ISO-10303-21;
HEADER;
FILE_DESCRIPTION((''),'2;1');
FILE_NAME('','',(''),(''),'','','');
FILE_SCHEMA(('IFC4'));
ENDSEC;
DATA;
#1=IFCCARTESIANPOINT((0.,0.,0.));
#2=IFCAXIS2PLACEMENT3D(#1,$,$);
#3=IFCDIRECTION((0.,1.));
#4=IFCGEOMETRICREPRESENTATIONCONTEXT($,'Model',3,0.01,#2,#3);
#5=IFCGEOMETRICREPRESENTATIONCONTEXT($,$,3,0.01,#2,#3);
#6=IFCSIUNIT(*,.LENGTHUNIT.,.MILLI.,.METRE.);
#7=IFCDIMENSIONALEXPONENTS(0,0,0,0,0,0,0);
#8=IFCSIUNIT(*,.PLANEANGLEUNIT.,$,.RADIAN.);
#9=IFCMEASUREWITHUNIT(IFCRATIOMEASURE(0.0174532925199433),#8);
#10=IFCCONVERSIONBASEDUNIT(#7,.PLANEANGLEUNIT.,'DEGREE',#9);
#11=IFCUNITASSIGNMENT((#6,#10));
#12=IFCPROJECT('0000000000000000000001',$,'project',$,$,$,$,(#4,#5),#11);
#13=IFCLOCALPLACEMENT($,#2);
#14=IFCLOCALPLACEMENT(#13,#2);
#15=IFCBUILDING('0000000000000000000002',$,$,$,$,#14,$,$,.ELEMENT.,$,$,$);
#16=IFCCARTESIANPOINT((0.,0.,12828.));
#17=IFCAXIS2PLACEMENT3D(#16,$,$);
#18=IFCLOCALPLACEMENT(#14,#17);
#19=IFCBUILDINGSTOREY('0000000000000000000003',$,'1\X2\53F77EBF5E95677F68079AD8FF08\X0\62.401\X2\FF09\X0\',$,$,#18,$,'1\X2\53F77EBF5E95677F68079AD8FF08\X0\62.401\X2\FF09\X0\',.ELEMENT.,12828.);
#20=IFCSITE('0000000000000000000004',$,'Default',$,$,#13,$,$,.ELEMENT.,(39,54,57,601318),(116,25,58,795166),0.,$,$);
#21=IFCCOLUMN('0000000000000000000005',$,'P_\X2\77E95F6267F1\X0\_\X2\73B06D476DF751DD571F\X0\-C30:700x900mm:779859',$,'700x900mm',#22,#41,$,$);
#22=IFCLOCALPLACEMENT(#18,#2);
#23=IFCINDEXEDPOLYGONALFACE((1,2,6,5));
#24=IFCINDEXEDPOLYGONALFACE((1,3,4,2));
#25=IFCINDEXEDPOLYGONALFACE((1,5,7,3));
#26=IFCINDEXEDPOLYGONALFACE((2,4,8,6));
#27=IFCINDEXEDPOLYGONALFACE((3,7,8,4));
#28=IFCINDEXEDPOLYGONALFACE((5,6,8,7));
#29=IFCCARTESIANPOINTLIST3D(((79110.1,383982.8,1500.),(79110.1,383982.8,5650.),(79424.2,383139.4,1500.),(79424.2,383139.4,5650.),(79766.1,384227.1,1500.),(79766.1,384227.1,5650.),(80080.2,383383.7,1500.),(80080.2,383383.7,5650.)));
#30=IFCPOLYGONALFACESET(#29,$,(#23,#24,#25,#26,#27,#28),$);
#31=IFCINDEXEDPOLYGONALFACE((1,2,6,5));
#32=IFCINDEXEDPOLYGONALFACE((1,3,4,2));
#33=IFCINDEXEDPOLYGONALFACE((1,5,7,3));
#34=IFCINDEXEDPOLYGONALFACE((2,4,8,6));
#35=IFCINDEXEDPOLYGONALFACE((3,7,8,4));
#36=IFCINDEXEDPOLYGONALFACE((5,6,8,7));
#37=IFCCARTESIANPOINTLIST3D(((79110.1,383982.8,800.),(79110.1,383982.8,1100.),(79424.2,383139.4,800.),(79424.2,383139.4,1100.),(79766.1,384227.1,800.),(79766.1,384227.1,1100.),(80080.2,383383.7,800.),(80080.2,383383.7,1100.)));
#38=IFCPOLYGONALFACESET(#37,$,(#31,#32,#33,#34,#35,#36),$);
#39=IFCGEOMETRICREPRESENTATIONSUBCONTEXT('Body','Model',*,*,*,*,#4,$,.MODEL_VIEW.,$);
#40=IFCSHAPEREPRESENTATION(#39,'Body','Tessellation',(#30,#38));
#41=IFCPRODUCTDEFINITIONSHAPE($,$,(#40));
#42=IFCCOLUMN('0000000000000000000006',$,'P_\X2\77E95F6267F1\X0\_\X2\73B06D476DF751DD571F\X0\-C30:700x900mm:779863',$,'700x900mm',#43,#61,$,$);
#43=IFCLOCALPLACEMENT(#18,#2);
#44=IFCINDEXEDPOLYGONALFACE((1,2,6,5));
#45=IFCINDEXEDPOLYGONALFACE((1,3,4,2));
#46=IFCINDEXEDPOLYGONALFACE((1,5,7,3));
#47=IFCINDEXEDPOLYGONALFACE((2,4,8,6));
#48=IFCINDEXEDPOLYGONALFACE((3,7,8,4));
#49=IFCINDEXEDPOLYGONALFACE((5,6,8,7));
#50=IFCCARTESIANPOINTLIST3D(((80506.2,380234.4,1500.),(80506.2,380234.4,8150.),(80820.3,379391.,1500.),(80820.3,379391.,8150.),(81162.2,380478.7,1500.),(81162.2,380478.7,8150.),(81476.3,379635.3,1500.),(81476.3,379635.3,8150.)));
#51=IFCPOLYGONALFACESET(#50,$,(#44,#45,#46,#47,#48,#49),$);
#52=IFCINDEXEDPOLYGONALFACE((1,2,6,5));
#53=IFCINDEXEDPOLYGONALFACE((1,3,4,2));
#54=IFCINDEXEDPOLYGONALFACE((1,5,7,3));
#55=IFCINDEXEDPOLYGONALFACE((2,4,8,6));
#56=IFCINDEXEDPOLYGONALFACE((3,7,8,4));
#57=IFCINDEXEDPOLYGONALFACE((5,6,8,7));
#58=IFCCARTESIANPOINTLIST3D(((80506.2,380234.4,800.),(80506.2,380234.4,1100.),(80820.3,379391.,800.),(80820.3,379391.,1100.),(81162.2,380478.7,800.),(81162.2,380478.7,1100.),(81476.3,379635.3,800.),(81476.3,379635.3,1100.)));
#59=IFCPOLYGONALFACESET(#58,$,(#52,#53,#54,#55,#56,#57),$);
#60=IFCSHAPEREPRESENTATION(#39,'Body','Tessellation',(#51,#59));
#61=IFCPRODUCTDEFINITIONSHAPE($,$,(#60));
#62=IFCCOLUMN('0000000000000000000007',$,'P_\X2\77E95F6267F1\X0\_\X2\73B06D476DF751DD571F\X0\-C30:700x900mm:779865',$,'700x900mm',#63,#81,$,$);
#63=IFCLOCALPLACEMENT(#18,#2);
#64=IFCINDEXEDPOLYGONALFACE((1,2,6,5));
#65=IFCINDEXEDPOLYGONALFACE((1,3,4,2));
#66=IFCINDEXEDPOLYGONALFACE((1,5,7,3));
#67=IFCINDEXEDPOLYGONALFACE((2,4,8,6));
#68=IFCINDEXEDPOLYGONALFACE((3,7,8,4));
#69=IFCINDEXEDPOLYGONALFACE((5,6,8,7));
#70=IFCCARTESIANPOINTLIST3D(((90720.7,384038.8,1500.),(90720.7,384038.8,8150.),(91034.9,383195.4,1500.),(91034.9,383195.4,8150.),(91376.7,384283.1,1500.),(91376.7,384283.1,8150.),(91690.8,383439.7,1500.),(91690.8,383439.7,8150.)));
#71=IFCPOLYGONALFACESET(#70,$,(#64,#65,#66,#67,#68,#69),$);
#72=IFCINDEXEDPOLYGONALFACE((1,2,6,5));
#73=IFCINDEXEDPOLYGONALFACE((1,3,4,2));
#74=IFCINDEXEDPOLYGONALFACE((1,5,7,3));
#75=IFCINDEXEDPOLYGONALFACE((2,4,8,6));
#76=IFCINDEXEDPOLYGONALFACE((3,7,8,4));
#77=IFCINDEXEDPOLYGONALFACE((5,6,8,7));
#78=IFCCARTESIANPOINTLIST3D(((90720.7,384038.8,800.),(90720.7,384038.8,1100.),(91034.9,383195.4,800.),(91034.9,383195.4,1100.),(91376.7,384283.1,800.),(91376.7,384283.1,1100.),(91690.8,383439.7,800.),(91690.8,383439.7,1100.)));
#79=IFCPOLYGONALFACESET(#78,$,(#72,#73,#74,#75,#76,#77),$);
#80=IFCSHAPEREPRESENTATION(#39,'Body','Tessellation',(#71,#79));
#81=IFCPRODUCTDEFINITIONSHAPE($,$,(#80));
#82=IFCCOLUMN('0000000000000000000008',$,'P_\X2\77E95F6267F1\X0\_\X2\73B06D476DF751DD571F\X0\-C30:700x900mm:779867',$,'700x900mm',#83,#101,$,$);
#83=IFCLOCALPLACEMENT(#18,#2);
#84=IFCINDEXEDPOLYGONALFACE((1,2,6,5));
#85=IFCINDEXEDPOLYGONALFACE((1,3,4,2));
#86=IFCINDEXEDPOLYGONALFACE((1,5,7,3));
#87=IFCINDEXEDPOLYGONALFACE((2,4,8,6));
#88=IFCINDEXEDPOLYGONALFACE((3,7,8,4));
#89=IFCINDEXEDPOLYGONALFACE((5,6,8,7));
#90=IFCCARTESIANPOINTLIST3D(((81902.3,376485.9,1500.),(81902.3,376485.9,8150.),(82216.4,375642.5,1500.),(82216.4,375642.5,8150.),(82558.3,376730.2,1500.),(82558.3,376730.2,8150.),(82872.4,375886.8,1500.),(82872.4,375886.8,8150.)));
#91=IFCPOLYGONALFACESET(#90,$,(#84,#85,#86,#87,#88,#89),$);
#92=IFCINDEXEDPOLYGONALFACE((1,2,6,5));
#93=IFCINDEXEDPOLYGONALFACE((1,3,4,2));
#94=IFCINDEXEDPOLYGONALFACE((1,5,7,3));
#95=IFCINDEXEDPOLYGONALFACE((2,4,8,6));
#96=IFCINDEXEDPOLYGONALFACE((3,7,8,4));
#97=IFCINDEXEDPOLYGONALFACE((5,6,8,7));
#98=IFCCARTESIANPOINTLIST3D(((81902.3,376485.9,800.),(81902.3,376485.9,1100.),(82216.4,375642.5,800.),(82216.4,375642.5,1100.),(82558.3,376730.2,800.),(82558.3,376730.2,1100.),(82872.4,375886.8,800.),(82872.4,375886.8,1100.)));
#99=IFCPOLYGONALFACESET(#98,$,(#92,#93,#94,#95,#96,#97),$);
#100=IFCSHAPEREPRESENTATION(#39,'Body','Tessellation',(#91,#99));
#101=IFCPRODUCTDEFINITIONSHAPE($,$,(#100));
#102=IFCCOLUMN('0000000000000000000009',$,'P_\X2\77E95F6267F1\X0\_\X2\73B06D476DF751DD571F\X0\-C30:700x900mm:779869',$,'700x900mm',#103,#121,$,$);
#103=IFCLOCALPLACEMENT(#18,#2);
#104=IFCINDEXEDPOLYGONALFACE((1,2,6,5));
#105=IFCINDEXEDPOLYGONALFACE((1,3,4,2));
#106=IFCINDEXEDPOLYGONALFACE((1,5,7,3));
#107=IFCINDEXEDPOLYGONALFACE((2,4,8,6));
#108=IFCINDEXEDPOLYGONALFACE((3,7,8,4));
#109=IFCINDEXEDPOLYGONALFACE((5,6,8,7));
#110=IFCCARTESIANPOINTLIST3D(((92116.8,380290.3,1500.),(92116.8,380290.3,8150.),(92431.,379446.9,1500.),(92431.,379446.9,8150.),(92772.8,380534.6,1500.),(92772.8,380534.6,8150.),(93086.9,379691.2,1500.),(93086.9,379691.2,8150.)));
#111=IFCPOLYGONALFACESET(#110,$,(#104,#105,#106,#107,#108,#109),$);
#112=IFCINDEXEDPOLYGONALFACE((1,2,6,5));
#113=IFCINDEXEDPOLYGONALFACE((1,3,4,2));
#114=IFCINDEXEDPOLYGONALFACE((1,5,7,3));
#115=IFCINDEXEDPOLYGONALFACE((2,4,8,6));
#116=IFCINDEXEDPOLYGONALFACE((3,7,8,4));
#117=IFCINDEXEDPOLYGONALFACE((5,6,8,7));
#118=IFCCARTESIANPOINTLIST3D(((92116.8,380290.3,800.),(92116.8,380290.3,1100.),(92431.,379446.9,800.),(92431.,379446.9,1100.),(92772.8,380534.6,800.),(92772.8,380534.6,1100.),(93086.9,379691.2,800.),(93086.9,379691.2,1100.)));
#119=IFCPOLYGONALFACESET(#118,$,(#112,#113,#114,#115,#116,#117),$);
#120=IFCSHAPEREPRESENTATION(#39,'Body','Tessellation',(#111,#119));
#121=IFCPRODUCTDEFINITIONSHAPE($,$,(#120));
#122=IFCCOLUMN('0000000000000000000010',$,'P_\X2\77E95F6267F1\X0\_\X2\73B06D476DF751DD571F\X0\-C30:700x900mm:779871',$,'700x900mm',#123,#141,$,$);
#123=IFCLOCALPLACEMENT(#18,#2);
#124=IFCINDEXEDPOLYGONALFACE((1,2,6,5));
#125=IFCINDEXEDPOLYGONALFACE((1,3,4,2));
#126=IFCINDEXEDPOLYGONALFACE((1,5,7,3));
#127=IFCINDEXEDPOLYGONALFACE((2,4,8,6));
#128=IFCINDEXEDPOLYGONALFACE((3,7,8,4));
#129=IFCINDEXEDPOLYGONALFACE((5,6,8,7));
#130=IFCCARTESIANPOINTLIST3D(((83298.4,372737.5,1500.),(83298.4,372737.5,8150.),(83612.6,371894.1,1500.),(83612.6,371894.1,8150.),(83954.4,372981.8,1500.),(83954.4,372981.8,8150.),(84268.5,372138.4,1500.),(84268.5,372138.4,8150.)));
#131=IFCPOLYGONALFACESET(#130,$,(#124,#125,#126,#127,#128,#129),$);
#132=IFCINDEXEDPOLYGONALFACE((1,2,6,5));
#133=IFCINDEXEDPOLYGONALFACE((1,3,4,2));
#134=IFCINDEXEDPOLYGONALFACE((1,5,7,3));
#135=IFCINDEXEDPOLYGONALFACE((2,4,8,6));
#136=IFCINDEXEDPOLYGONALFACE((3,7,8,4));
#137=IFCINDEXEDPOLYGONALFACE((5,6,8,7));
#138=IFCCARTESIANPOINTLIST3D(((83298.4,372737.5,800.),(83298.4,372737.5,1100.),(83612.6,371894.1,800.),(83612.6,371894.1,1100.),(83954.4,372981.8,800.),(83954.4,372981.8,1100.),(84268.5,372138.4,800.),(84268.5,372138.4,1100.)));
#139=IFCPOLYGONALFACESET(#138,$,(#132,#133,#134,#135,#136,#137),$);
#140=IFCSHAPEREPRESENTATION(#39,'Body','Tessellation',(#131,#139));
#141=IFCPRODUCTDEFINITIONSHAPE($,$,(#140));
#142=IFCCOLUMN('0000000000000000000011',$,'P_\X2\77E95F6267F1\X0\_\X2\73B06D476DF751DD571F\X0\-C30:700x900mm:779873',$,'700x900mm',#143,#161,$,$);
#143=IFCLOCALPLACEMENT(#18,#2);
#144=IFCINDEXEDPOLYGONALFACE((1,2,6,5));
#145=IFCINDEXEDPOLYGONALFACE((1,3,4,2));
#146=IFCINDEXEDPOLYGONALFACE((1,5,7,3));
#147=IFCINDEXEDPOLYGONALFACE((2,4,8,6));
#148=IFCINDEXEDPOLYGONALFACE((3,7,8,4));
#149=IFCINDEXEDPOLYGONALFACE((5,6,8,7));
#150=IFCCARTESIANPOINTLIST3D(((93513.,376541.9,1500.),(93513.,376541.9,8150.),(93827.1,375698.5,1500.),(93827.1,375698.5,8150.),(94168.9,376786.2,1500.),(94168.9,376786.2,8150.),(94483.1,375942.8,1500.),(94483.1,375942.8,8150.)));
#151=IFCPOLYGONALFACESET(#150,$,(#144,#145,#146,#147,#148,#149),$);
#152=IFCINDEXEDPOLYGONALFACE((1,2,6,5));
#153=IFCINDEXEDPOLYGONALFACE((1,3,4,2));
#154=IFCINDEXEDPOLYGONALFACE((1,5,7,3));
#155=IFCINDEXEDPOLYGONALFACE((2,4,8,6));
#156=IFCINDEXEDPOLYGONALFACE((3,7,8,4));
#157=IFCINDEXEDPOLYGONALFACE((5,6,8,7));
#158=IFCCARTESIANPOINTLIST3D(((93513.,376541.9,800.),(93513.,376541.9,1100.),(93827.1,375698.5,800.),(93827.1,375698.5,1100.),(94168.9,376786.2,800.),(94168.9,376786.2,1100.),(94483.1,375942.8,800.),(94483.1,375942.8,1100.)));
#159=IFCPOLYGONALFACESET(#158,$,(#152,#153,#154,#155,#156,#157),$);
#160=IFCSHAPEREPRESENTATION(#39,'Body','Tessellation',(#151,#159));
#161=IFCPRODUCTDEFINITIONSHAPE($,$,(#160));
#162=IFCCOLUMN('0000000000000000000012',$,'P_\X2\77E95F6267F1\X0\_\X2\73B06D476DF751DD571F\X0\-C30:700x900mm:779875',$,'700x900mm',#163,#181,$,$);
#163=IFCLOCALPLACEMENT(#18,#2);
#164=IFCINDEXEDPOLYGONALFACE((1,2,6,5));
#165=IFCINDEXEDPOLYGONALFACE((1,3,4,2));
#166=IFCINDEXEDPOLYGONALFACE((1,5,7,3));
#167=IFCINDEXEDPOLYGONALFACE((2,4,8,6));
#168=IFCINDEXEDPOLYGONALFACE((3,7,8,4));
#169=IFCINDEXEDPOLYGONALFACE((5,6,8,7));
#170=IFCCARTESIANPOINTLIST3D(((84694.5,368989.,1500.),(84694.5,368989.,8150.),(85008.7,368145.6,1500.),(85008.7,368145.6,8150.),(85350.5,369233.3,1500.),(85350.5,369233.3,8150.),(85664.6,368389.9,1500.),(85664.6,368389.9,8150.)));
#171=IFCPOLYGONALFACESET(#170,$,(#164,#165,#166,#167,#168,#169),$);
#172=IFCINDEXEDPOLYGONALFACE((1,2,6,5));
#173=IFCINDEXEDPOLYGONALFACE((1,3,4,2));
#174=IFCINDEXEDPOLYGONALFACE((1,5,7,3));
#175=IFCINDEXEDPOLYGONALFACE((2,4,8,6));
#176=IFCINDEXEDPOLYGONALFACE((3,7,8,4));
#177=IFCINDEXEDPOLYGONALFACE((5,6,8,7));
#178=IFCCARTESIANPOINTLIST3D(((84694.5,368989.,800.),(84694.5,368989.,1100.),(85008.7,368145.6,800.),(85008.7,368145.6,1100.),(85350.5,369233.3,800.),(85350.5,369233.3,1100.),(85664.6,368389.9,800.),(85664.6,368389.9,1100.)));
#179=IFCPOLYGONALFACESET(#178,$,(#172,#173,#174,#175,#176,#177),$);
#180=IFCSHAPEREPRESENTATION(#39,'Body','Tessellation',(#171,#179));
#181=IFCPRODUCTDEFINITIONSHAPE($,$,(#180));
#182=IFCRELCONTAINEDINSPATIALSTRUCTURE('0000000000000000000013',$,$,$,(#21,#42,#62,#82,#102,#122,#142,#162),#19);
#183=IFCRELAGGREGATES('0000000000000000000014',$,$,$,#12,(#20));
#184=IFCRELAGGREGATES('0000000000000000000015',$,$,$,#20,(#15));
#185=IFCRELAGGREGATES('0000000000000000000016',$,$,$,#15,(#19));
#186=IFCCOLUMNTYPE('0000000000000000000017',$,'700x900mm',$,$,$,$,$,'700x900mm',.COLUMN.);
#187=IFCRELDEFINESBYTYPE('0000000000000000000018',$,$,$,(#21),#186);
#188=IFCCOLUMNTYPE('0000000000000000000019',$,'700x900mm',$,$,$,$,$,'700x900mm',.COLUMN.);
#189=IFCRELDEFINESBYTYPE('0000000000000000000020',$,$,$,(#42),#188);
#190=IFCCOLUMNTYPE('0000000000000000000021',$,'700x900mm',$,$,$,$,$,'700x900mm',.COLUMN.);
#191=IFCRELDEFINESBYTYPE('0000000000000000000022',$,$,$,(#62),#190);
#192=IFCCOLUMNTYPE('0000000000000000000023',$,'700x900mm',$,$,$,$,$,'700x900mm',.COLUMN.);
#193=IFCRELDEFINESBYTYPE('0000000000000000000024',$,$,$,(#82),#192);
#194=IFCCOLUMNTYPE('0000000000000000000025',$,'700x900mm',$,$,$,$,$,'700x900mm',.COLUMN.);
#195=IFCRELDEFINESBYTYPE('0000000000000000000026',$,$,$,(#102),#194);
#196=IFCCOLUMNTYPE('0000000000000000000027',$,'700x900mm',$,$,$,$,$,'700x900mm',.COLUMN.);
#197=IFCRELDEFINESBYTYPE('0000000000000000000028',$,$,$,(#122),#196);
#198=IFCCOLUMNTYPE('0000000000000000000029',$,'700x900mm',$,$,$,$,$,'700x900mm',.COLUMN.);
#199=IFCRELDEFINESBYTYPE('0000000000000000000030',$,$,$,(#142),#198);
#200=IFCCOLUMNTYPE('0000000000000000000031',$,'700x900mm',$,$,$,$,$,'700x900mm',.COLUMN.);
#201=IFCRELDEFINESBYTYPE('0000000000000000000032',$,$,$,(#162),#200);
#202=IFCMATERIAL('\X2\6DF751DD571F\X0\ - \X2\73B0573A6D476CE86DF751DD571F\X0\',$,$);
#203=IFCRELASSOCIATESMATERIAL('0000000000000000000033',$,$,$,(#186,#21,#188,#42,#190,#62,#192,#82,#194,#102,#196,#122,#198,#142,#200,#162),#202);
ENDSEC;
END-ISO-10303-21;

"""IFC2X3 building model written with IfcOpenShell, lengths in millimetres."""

from ifc_helpers import new_model, entity, si_unit, converted_unit, direction, frame, frame_2d, origin, origin_2d_with_axis, place, context, subcontext, project, spatial, rectangle, extrude, source, transform, mapped, material, type_object, type_shapes, element, save


model = new_model("IFC2X3")

# Units and contexts
model_context = context("Model", 3, precision=0.01, world=origin(), true_north=direction((0.0, 1.0)))
context_of_model = context(None, 3, precision=0.01, world=origin(), true_north=direction((0.0, 1.0)))
body_context = subcontext(model_context, "Body", "Model", "MODEL_VIEW")
ifc_project = project(units=[si_unit("LENGTHUNIT", "METRE", prefix="MILLI"), converted_unit("PLANEANGLEUNIT", "DEGREE", entity("IfcRatioMeasure", 0.0174532925199433), si_unit("PLANEANGLEUNIT", "RADIAN"), dimensions=[0, 0, 0, 0, 0, 0, 0])], contexts=[model_context, context_of_model])

# Site, building, storey
site_placement = place(None, origin())
site = spatial("IfcSite", under=ifc_project, at=site_placement, Name="Default", CompositionType="ELEMENT", RefLatitude=(39, 54, 57, 601318), RefLongitude=(116, 25, 58, 795166), RefElevation=0.0)
building_placement = place(site_placement, origin())
building = spatial("IfcBuilding", under=site, at=building_placement, CompositionType="ELEMENT")
storey_placement = place(building_placement, frame((0.0, 0.0, 12828.0)))
storey = spatial("IfcBuildingStorey", under=building, at=storey_placement, Name="1号线底板标高（62.401）", LongName="1号线底板标高（62.401）", CompositionType="ELEMENT", Elevation=12828.0)

# Columns
ifc_material_1 = material(Name="混凝土 - 现场浇注混凝土")
column_type_1 = type_object("IfcColumnType", Name="700x900mm", ElementType="700x900mm", PredefinedType="COLUMN", material=ifc_material_1)
shared_shape_1 = source(origin(), body_context, "Body", "SweptSolid", [
    extrude(rectangle(XDim=700.0, YDim=900.0, at=origin_2d_with_axis()), frame((485.1, 543.9, 700.0), z_axis=(0.0, 0.0, 1.0), x_axis=(-0.937112, -0.349028, 0.0)), (0.0, 0.0, 1.0), 4150.0),
    extrude(rectangle(XDim=700.0, YDim=900.0, at=origin_2d_with_axis()), frame((485.1, 543.9, 0.0), z_axis=(0.0, 0.0, 1.0), x_axis=(-0.937112, -0.349028, 0.0)), (0.0, 0.0, 1.0), 300.0),
])
type_shapes(column_type_1, [shared_shape_1])
column_1_placement = place(storey_placement, frame((79110.1, 383139.4, 800.0)))
element("IfcColumn", 1, at=column_1_placement, inside=storey, type_object=column_type_1, material=ifc_material_1, Name="P_矩形柱_现浇混凝土-C30:700x900mm:779859", ObjectType="700x900mm", context=body_context, shape_type="MappedRepresentation", body=[
    mapped(shared_shape_1, transform((0.0, 0.0, 0.0), scale=1.0)),
])
column_type_2 = type_object("IfcColumnType", Name="700x900mm", ElementType="700x900mm", PredefinedType="COLUMN", material=ifc_material_1)
shared_shape_2 = source(origin(), body_context, "Body", "SweptSolid", [
    extrude(rectangle(XDim=700.0, YDim=900.0, at=frame_2d((0.0, 0.0), x_axis=(1.0, 0.0))), frame((485.1, 543.9, 700.0), z_axis=(0.0, 0.0, 1.0), x_axis=(-0.937112, -0.349028, 0.0)), (0.0, 0.0, 1.0), 6650.0),
    extrude(rectangle(XDim=700.0, YDim=900.0, at=frame_2d((0.0, 0.0), x_axis=(1.0, 0.0))), frame((485.1, 543.9, 0.0), z_axis=(0.0, 0.0, 1.0), x_axis=(-0.937112, -0.349028, 0.0)), (0.0, 0.0, 1.0), 300.0),
])
type_shapes(column_type_2, [shared_shape_2])
column_2_placement = place(storey_placement, frame((80506.2, 379391.0, 800.0)))
element("IfcColumn", 2, at=column_2_placement, inside=storey, type_object=column_type_2, material=ifc_material_1, Name="P_矩形柱_现浇混凝土-C30:700x900mm:779863", ObjectType="700x900mm", context=body_context, shape_type="MappedRepresentation", body=[
    mapped(shared_shape_2, transform((0.0, 0.0, 0.0), scale=1.0)),
])
column_type_3 = type_object("IfcColumnType", Name="700x900mm", ElementType="700x900mm", PredefinedType="COLUMN", material=ifc_material_1)
shared_shape_3 = source(origin(), body_context, "Body", "SweptSolid", [
    extrude(rectangle(XDim=700.0, YDim=900.0, at=frame_2d((0.0, 0.0), x_axis=(1.0, 0.0))), frame((485.1, 543.9, 700.0), z_axis=(0.0, 0.0, 1.0), x_axis=(-0.937112, -0.349028, 0.0)), (0.0, 0.0, 1.0), 6650.0),
    extrude(rectangle(XDim=700.0, YDim=900.0, at=frame_2d((0.0, 0.0), x_axis=(1.0, 0.0))), frame((485.1, 543.9, 0.0), z_axis=(0.0, 0.0, 1.0), x_axis=(-0.937112, -0.349028, 0.0)), (0.0, 0.0, 1.0), 300.0),
])
type_shapes(column_type_3, [shared_shape_3])
column_3_placement = place(storey_placement, frame((90720.7, 383195.4, 800.0)))
element("IfcColumn", 3, at=column_3_placement, inside=storey, type_object=column_type_3, material=ifc_material_1, Name="P_矩形柱_现浇混凝土-C30:700x900mm:779865", ObjectType="700x900mm", context=body_context, shape_type="MappedRepresentation", body=[
    mapped(shared_shape_3, transform((0.0, 0.0, 0.0), scale=1.0)),
])
column_type_4 = type_object("IfcColumnType", Name="700x900mm", ElementType="700x900mm", PredefinedType="COLUMN", material=ifc_material_1)
shared_shape_4 = source(origin(), body_context, "Body", "SweptSolid", [
    extrude(rectangle(XDim=700.0, YDim=900.0, at=frame_2d((0.0, 0.0), x_axis=(1.0, 0.0))), frame((485.1, 543.9, 700.0), z_axis=(0.0, 0.0, 1.0), x_axis=(-0.937112, -0.349028, 0.0)), (0.0, 0.0, 1.0), 6650.0),
    extrude(rectangle(XDim=700.0, YDim=900.0, at=frame_2d((0.0, 0.0), x_axis=(1.0, 0.0))), frame((485.1, 543.9, 0.0), z_axis=(0.0, 0.0, 1.0), x_axis=(-0.937112, -0.349028, 0.0)), (0.0, 0.0, 1.0), 300.0),
])
type_shapes(column_type_4, [shared_shape_4])
column_4_placement = place(storey_placement, frame((81902.3, 375642.5, 800.0)))
element("IfcColumn", 4, at=column_4_placement, inside=storey, type_object=column_type_4, material=ifc_material_1, Name="P_矩形柱_现浇混凝土-C30:700x900mm:779867", ObjectType="700x900mm", context=body_context, shape_type="MappedRepresentation", body=[
    mapped(shared_shape_4, transform((0.0, 0.0, 0.0), scale=1.0)),
])
column_type_5 = type_object("IfcColumnType", Name="700x900mm", ElementType="700x900mm", PredefinedType="COLUMN", material=ifc_material_1)
shared_shape_5 = source(origin(), body_context, "Body", "SweptSolid", [
    extrude(rectangle(XDim=700.0, YDim=900.0, at=frame_2d((0.0, 0.0), x_axis=(1.0, 0.0))), frame((485.1, 543.9, 700.0), z_axis=(0.0, 0.0, 1.0), x_axis=(-0.937112, -0.349028, 0.0)), (0.0, 0.0, 1.0), 6650.0),
    extrude(rectangle(XDim=700.0, YDim=900.0, at=frame_2d((0.0, 0.0), x_axis=(1.0, 0.0))), frame((485.1, 543.9, 0.0), z_axis=(0.0, 0.0, 1.0), x_axis=(-0.937112, -0.349028, 0.0)), (0.0, 0.0, 1.0), 300.0),
])
type_shapes(column_type_5, [shared_shape_5])
column_5_placement = place(storey_placement, frame((92116.8, 379446.9, 800.0)))
element("IfcColumn", 5, at=column_5_placement, inside=storey, type_object=column_type_5, material=ifc_material_1, Name="P_矩形柱_现浇混凝土-C30:700x900mm:779869", ObjectType="700x900mm", context=body_context, shape_type="MappedRepresentation", body=[
    mapped(shared_shape_5, transform((0.0, 0.0, 0.0), scale=1.0)),
])
column_type_6 = type_object("IfcColumnType", Name="700x900mm", ElementType="700x900mm", PredefinedType="COLUMN", material=ifc_material_1)
shared_shape_6 = source(origin(), body_context, "Body", "SweptSolid", [
    extrude(rectangle(XDim=700.0, YDim=900.0, at=frame_2d((0.0, 0.0), x_axis=(1.0, 0.0))), frame((485.1, 543.9, 700.0), z_axis=(0.0, 0.0, 1.0), x_axis=(-0.937112, -0.349028, 0.0)), (0.0, 0.0, 1.0), 6650.0),
    extrude(rectangle(XDim=700.0, YDim=900.0, at=frame_2d((0.0, 0.0), x_axis=(1.0, 0.0))), frame((485.1, 543.9, 0.0), z_axis=(0.0, 0.0, 1.0), x_axis=(-0.937112, -0.349028, 0.0)), (0.0, 0.0, 1.0), 300.0),
])
type_shapes(column_type_6, [shared_shape_6])
column_6_placement = place(storey_placement, frame((83298.4, 371894.1, 800.0)))
element("IfcColumn", 6, at=column_6_placement, inside=storey, type_object=column_type_6, material=ifc_material_1, Name="P_矩形柱_现浇混凝土-C30:700x900mm:779871", ObjectType="700x900mm", context=body_context, shape_type="MappedRepresentation", body=[
    mapped(shared_shape_6, transform((0.0, 0.0, 0.0), scale=1.0)),
])
column_type_7 = type_object("IfcColumnType", Name="700x900mm", ElementType="700x900mm", PredefinedType="COLUMN", material=ifc_material_1)
shared_shape_7 = source(origin(), body_context, "Body", "SweptSolid", [
    extrude(rectangle(XDim=700.0, YDim=900.0, at=frame_2d((0.0, 0.0), x_axis=(1.0, 0.0))), frame((485.1, 543.9, 700.0), z_axis=(0.0, 0.0, 1.0), x_axis=(-0.937112, -0.349028, 0.0)), (0.0, 0.0, 1.0), 6650.0),
    extrude(rectangle(XDim=700.0, YDim=900.0, at=frame_2d((0.0, 0.0), x_axis=(1.0, 0.0))), frame((485.1, 543.9, 0.0), z_axis=(0.0, 0.0, 1.0), x_axis=(-0.937112, -0.349028, 0.0)), (0.0, 0.0, 1.0), 300.0),
])
type_shapes(column_type_7, [shared_shape_7])
column_7_placement = place(storey_placement, frame((93513.0, 375698.5, 800.0)))
element("IfcColumn", 7, at=column_7_placement, inside=storey, type_object=column_type_7, material=ifc_material_1, Name="P_矩形柱_现浇混凝土-C30:700x900mm:779873", ObjectType="700x900mm", context=body_context, shape_type="MappedRepresentation", body=[
    mapped(shared_shape_7, transform((0.0, 0.0, 0.0), scale=1.0)),
])
column_type_8 = type_object("IfcColumnType", Name="700x900mm", ElementType="700x900mm", PredefinedType="COLUMN", material=ifc_material_1)
shared_shape_8 = source(origin(), body_context, "Body", "SweptSolid", [
    extrude(rectangle(XDim=700.0, YDim=900.0, at=frame_2d((0.0, 0.0), x_axis=(1.0, 0.0))), frame((485.1, 543.9, 700.0), z_axis=(0.0, 0.0, 1.0), x_axis=(-0.937112, -0.349028, 0.0)), (0.0, 0.0, 1.0), 6650.0),
    extrude(rectangle(XDim=700.0, YDim=900.0, at=frame_2d((0.0, 0.0), x_axis=(1.0, 0.0))), frame((485.1, 543.9, 0.0), z_axis=(0.0, 0.0, 1.0), x_axis=(-0.937112, -0.349028, 0.0)), (0.0, 0.0, 1.0), 300.0),
])
type_shapes(column_type_8, [shared_shape_8])
column_8_placement = place(storey_placement, frame((84694.5, 368145.6, 800.0)))
element("IfcColumn", 8, at=column_8_placement, inside=storey, type_object=column_type_8, material=ifc_material_1, Name="P_矩形柱_现浇混凝土-C30:700x900mm:779875", ObjectType="700x900mm", context=body_context, shape_type="MappedRepresentation", body=[
    mapped(shared_shape_8, transform((0.0, 0.0, 0.0), scale=1.0)),
])

save(model, "model.ifc")
